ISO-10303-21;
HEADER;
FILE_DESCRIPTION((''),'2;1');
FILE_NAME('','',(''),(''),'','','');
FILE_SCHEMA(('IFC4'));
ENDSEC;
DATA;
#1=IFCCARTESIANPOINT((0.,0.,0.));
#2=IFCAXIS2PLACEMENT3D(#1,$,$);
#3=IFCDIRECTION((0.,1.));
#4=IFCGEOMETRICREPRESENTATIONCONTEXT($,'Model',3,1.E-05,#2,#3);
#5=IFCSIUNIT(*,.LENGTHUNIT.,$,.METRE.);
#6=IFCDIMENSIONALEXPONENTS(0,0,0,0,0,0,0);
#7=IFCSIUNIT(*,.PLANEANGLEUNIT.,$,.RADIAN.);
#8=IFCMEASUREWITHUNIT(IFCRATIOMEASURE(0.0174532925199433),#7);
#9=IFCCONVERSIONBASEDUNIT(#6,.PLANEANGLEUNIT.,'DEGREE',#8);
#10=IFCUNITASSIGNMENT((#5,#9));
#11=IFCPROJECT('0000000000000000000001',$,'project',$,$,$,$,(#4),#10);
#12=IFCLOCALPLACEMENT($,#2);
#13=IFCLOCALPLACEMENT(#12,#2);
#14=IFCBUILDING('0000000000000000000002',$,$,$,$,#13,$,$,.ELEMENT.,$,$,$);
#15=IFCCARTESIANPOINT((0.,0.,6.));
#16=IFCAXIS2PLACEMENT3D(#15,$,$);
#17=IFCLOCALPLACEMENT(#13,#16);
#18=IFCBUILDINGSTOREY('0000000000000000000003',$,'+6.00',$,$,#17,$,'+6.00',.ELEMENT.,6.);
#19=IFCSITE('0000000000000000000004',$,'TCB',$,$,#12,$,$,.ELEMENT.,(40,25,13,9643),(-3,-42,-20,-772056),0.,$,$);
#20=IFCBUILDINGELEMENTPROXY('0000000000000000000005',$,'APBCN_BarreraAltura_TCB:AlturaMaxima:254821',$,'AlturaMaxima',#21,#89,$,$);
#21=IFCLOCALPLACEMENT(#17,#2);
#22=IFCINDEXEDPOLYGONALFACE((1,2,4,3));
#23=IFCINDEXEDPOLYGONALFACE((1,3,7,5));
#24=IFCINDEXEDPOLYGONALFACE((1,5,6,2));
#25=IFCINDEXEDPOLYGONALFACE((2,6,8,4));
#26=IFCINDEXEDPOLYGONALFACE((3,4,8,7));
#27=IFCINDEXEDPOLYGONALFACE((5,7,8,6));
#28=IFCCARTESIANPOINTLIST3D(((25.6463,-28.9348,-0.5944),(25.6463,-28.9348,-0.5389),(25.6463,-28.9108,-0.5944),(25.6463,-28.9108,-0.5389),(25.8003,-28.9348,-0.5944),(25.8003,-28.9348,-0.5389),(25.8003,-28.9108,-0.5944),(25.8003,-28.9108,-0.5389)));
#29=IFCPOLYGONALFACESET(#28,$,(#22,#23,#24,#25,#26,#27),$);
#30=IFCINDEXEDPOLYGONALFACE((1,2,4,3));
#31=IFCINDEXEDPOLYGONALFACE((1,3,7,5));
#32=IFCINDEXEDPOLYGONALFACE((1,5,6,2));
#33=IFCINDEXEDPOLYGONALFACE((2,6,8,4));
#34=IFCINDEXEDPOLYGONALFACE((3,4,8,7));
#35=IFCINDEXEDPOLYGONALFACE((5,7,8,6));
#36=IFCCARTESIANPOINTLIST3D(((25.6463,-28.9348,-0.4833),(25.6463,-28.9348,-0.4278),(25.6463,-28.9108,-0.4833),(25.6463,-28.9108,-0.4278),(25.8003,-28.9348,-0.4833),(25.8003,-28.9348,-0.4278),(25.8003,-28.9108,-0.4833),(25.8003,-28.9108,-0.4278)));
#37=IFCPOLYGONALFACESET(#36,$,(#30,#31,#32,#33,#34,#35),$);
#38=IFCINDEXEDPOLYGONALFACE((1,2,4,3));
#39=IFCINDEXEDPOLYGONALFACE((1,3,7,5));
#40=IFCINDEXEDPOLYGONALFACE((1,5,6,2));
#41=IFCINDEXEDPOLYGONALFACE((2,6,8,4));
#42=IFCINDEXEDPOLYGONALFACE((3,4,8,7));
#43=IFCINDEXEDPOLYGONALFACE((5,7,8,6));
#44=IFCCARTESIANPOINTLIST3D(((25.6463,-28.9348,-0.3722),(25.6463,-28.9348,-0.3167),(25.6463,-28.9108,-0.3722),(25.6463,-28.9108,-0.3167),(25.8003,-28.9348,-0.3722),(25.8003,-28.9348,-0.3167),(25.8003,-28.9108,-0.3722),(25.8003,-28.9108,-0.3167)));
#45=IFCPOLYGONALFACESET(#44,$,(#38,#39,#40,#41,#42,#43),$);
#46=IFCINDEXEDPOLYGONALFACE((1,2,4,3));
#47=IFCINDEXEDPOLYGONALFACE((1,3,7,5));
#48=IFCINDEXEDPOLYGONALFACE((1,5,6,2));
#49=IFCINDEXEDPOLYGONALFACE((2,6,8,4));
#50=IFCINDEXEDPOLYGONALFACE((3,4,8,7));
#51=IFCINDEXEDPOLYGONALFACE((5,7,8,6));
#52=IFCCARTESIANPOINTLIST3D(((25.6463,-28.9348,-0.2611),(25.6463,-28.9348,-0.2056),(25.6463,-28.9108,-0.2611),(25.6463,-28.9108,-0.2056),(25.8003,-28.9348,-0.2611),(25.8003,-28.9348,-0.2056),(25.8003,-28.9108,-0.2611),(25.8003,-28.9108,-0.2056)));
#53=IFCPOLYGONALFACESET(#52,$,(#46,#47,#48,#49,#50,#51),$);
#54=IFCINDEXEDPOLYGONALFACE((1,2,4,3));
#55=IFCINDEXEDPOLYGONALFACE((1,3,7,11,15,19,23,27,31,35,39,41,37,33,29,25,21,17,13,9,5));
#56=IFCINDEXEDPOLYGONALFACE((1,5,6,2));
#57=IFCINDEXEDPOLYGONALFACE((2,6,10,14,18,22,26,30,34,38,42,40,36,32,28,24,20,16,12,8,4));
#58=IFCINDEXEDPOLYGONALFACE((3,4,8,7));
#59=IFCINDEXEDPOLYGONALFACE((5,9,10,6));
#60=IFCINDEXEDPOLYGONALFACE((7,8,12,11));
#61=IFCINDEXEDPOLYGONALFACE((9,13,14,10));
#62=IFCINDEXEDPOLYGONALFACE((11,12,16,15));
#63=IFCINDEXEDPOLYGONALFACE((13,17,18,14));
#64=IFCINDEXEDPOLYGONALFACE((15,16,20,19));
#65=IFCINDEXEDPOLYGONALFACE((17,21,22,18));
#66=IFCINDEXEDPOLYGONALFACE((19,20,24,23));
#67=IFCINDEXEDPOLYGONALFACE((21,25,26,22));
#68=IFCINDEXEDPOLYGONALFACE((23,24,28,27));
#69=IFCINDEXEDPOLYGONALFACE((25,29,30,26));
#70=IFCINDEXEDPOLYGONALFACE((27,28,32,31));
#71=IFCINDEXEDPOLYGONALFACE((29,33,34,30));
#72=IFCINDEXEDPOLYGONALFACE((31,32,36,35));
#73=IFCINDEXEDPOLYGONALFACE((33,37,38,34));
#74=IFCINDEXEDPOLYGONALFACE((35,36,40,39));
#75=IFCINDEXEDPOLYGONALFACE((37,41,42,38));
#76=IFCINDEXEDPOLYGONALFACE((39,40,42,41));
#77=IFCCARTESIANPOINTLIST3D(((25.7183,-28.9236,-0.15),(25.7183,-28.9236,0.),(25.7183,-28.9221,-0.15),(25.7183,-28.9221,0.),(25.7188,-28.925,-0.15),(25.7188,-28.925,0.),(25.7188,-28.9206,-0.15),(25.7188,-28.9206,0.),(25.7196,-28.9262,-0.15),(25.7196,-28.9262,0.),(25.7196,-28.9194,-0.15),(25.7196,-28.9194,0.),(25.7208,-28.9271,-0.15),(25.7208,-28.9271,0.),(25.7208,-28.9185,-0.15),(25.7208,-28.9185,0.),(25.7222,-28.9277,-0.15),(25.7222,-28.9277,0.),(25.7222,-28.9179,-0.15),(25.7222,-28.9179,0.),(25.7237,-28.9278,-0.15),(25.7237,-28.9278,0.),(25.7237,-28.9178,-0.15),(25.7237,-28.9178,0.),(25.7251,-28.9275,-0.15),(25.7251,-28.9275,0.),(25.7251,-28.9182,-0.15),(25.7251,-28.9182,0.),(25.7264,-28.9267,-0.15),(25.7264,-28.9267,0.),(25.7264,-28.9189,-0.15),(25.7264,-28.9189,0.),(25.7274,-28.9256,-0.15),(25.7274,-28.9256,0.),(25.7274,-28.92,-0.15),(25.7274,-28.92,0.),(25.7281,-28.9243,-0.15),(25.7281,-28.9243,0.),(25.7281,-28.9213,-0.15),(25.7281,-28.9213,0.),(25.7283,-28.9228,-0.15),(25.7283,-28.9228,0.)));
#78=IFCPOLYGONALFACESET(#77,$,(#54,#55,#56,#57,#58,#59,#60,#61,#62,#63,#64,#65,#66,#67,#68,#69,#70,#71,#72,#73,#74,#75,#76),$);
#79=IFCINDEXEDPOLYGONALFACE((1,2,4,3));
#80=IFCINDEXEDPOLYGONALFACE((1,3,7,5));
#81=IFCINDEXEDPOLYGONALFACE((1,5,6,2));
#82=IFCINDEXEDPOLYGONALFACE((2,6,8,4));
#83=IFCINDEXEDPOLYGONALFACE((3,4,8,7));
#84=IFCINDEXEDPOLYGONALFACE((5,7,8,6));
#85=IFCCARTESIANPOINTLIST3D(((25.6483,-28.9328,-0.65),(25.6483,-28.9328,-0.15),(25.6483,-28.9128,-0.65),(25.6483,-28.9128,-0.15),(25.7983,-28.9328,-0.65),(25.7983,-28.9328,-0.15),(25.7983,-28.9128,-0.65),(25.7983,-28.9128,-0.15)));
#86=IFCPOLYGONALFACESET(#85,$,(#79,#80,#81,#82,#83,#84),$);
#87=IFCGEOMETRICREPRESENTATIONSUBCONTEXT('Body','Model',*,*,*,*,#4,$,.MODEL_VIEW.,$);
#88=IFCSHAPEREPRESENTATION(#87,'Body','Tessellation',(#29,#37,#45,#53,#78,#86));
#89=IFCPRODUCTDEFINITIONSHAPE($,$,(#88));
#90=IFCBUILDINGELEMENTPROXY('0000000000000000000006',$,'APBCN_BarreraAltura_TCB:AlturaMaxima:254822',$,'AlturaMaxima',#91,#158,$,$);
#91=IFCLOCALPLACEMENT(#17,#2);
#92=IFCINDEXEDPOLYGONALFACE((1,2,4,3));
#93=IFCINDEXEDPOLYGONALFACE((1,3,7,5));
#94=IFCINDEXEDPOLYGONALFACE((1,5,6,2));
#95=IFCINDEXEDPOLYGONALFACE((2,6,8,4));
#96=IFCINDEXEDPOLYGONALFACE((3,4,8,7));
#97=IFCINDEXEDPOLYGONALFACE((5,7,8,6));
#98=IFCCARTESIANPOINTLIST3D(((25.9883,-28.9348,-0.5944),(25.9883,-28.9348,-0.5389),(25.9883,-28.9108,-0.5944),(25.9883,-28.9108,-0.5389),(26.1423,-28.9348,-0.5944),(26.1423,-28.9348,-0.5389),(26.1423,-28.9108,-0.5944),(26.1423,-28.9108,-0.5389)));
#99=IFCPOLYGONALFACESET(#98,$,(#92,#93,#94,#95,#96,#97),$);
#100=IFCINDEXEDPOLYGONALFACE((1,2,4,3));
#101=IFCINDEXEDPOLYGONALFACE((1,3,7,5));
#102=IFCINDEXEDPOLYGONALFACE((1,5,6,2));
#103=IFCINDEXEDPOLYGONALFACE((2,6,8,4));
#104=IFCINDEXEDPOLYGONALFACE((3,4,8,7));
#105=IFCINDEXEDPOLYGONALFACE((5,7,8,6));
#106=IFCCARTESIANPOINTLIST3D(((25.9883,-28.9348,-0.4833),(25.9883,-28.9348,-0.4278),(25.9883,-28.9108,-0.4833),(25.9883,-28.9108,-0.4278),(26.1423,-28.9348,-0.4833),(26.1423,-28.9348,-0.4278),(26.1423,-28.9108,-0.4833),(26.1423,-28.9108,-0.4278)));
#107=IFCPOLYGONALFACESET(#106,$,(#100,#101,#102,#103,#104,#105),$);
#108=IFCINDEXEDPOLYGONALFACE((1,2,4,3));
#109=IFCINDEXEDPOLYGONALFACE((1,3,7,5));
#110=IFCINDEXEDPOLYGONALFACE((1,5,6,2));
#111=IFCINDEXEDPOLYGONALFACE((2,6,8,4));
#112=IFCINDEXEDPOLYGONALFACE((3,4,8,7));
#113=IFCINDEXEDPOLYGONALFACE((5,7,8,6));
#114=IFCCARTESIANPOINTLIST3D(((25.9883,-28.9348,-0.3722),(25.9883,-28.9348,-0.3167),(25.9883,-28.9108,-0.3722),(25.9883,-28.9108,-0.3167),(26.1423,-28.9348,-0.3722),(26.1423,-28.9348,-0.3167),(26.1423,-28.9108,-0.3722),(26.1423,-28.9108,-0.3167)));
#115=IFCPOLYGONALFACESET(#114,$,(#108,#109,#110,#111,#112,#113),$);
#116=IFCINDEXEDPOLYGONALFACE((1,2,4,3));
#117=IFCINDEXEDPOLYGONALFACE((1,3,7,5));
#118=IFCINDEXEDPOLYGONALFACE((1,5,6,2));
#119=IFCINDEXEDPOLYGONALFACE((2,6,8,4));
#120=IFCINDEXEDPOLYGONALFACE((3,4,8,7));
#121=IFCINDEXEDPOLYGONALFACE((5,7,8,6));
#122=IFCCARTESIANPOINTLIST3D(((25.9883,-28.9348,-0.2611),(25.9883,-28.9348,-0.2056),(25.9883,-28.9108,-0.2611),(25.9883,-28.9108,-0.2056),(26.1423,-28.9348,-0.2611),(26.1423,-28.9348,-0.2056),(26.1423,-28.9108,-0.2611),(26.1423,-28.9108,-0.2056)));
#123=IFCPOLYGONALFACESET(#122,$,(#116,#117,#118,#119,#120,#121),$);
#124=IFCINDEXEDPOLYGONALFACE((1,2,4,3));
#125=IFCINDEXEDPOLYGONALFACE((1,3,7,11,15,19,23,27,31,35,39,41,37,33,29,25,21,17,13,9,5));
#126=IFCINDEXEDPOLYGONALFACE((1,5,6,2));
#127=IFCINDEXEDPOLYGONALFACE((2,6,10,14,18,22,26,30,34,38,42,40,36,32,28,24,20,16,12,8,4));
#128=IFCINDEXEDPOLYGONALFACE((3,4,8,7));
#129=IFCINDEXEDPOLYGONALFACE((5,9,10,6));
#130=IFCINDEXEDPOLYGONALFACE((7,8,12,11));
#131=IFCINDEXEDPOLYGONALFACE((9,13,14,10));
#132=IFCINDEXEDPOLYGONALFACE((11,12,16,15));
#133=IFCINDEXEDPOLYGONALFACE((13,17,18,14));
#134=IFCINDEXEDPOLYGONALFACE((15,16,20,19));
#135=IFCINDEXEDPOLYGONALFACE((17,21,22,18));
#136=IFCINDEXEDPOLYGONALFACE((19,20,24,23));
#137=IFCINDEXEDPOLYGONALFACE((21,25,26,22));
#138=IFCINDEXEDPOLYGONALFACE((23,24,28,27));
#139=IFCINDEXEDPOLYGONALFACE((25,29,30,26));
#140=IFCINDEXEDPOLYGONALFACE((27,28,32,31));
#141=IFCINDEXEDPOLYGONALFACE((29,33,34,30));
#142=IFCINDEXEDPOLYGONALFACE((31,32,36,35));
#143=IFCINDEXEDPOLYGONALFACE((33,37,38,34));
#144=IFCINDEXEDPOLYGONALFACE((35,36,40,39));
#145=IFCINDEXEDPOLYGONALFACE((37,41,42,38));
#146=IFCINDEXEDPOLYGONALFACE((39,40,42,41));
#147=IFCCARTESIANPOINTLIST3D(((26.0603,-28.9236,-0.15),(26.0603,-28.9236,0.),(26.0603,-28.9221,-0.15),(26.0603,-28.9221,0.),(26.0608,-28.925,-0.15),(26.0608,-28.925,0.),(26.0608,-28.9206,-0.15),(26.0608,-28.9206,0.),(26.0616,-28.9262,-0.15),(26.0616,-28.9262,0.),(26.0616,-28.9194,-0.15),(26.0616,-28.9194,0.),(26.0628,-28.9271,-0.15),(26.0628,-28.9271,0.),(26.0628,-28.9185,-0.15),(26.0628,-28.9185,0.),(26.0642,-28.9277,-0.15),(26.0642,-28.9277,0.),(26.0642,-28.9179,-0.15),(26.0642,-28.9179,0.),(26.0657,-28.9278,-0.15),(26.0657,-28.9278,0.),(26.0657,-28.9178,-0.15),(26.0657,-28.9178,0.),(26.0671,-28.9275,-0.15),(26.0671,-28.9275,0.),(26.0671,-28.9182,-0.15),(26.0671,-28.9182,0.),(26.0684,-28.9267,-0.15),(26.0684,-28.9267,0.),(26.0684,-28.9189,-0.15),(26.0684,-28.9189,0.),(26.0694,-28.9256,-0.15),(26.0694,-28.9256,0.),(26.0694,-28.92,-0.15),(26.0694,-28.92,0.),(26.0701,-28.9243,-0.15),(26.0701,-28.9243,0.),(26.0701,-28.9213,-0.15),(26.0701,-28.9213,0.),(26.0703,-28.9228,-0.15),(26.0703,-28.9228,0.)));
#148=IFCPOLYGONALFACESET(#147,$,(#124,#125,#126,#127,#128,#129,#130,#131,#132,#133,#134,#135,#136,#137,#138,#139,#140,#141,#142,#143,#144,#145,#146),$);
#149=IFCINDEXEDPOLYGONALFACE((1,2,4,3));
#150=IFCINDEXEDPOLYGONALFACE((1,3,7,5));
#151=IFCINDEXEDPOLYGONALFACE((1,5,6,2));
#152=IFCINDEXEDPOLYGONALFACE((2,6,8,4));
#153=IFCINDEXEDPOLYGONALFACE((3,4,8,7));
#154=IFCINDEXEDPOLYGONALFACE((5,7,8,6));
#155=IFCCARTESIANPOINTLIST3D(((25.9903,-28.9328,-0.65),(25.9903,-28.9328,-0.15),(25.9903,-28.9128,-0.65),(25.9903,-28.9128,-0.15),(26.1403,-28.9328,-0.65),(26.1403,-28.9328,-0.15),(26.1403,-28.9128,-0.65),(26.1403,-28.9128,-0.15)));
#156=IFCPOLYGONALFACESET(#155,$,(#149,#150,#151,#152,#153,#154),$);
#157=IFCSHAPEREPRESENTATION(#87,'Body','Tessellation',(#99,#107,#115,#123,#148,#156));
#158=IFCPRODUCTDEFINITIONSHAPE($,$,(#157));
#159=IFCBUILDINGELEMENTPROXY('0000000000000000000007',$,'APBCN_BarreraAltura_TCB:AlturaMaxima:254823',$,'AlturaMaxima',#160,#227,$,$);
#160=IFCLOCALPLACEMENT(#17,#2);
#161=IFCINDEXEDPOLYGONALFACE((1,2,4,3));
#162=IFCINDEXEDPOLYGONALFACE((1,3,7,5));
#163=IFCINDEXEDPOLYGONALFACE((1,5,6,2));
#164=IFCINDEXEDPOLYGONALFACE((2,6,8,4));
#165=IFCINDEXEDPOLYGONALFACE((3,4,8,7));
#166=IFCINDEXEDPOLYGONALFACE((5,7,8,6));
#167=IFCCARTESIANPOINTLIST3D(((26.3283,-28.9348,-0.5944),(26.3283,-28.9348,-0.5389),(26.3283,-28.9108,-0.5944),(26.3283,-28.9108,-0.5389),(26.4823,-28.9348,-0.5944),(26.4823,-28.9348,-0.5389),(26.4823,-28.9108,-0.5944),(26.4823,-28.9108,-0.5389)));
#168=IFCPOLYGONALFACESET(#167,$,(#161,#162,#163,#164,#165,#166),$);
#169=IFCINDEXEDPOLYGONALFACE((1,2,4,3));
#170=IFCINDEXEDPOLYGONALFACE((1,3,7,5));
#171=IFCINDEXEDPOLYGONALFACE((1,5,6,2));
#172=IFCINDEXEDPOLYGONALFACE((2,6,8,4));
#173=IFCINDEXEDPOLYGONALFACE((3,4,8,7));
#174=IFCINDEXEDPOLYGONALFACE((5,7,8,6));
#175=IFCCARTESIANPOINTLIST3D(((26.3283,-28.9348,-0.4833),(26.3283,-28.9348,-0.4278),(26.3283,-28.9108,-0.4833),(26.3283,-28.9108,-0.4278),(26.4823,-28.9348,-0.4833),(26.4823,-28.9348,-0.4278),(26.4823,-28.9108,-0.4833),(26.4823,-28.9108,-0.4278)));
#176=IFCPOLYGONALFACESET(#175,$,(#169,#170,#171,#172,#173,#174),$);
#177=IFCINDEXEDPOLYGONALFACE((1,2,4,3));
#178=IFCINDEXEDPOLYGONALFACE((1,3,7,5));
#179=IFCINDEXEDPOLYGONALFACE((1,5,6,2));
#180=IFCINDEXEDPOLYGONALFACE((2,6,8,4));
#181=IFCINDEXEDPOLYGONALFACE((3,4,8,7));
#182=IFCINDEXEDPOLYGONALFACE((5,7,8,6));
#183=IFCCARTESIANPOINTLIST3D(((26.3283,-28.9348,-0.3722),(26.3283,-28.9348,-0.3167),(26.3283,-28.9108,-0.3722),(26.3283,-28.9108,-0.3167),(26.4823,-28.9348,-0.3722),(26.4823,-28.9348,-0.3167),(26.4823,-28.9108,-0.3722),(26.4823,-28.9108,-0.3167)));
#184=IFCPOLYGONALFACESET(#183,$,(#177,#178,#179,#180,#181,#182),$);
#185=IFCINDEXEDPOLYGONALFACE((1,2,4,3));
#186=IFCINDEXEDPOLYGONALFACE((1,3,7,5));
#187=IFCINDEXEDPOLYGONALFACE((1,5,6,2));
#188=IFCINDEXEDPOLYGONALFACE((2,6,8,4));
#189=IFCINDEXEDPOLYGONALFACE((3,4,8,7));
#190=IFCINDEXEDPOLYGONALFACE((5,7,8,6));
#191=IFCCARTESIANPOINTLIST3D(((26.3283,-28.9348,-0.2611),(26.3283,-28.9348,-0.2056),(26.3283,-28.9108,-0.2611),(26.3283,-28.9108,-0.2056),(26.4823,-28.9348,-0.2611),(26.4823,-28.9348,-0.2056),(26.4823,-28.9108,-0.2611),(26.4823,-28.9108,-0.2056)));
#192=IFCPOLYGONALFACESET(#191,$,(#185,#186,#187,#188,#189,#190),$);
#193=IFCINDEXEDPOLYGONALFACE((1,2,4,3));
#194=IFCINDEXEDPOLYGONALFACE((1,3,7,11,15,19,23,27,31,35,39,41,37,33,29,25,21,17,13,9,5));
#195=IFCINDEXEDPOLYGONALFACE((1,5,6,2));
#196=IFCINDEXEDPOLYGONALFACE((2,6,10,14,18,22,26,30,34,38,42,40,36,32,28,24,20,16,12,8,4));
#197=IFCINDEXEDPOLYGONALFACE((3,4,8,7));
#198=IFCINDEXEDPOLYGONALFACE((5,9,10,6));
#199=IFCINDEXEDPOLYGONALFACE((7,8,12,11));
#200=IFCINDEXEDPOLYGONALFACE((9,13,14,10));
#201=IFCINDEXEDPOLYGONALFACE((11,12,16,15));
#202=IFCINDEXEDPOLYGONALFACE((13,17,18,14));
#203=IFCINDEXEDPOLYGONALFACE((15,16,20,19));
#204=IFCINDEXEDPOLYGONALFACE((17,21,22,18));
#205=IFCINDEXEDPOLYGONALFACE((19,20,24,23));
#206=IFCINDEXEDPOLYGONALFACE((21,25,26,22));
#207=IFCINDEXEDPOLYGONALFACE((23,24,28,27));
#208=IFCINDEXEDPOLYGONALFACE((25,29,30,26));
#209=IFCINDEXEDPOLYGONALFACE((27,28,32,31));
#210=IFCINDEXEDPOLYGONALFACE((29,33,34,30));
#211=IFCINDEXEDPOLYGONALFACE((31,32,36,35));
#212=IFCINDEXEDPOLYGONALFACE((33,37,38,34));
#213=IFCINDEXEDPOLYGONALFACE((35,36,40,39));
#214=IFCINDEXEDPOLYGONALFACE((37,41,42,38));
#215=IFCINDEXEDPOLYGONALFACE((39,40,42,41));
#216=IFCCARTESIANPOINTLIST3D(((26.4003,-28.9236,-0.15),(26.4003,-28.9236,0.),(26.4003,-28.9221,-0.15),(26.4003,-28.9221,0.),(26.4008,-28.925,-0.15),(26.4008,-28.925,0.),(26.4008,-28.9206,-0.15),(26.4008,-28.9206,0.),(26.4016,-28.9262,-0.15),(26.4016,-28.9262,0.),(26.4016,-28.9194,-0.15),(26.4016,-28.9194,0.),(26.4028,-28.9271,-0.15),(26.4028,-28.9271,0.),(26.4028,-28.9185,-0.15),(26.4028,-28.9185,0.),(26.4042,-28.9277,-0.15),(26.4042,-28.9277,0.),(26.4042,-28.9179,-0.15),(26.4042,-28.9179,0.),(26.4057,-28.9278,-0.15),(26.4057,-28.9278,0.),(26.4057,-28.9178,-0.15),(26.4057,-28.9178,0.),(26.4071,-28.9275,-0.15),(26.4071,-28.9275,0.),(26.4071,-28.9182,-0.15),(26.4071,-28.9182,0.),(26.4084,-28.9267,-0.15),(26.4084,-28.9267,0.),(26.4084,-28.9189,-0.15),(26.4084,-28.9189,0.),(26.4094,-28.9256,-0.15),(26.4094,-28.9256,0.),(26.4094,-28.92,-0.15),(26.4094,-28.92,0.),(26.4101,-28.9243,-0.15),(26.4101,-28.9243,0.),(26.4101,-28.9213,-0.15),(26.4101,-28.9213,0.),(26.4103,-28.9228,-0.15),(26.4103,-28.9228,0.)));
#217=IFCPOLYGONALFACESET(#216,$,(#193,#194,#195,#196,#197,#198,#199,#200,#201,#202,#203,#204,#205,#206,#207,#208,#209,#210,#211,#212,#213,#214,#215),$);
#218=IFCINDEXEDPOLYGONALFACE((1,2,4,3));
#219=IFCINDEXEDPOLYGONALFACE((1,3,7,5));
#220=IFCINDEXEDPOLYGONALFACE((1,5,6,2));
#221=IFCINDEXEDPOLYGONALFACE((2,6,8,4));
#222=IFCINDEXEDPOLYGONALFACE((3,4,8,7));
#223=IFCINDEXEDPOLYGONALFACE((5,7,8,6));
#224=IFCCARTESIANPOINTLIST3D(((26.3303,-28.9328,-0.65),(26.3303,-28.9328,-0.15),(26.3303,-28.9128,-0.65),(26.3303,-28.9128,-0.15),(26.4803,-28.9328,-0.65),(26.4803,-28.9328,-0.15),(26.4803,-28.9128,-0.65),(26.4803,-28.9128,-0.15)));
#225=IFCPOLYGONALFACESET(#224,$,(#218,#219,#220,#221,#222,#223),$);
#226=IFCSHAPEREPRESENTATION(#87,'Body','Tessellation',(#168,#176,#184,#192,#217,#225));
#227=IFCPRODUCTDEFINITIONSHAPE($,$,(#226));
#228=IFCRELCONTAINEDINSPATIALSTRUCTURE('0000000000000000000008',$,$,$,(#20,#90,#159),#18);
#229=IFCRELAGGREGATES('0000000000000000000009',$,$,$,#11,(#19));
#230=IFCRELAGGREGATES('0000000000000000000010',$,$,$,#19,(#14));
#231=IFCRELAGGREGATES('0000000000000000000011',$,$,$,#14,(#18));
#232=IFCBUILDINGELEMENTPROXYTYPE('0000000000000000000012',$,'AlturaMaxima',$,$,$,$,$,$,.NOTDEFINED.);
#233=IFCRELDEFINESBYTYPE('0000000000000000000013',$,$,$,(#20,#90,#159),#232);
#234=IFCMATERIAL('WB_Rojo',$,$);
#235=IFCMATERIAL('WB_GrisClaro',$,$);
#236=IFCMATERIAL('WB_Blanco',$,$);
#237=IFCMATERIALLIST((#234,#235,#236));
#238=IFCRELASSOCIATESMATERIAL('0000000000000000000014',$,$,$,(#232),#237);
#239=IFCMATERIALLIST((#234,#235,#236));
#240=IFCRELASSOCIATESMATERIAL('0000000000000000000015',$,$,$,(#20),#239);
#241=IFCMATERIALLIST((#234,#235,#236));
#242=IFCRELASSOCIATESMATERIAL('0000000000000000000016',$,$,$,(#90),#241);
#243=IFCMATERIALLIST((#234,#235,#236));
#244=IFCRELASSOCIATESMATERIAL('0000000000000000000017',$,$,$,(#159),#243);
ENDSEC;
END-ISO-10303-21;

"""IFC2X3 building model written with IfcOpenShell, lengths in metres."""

from ifc_helpers import new_model, entity, si_unit, converted_unit, direction, frame, frame_2d, origin, origin_2d_with_axis, place, context, subcontext, project, spatial, rectangle, circle, extrude, source, transform, mapped, material, material_list, type_object, type_shapes, element, save


model = new_model("IFC2X3")

# Units and contexts
model_context = context("Model", 3, precision=1e-05, world=origin(), true_north=direction((0.0, 1.0)))
body_context = subcontext(model_context, "Body", "Model", "MODEL_VIEW")
ifc_project = project(units=[si_unit("LENGTHUNIT", "METRE"), converted_unit("PLANEANGLEUNIT", "DEGREE", entity("IfcRatioMeasure", 0.0174532925199433), si_unit("PLANEANGLEUNIT", "RADIAN"), dimensions=[0, 0, 0, 0, 0, 0, 0])], contexts=[model_context])

# Site, building, storey
site_placement = place(None, origin())
site = spatial("IfcSite", under=ifc_project, at=site_placement, Name="TCB", CompositionType="ELEMENT", RefLatitude=(40, 25, 13, 9643), RefLongitude=(-3, -42, -20, -772056), RefElevation=0.0)
building_placement = place(site_placement, origin())
building = spatial("IfcBuilding", under=site, at=building_placement, CompositionType="ELEMENT")
storey_placement = place(building_placement, frame((0.0, 0.0, 6.0)))
storey = spatial("IfcBuildingStorey", under=building, at=storey_placement, Name="+6.00", LongName="+6.00", CompositionType="ELEMENT", Elevation=6.0)

# Building element proxies
ifc_material_1 = material(Name="WB_Rojo")
ifc_material_2 = material(Name="WB_GrisClaro")
ifc_material_3 = material(Name="WB_Blanco")
ifc_material_list_1 = material_list([ifc_material_1, ifc_material_2, ifc_material_3])
building_element_proxy_type = type_object("IfcBuildingElementProxyType", Name="AlturaMaxima", PredefinedType="NOTDEFINED", material=ifc_material_list_1)
shared_shape = source(origin(), body_context, "Body", "SweptSolid", [
    extrude(rectangle(XDim=0.154, YDim=0.024, at=frame_2d((0.0, 0.0), x_axis=(1.0, 0.0))), frame((0.0, 0.0, -0.5944), z_axis=(0.0, 0.0, 1.0), x_axis=(-1.0, 0.0, 0.0)), (0.0, 0.0, 1.0), 0.0556),
    extrude(rectangle(XDim=0.154, YDim=0.024, at=frame_2d((0.0, 0.0), x_axis=(1.0, 0.0))), frame((0.0, 0.0, -0.4833), z_axis=(0.0, 0.0, 1.0), x_axis=(-1.0, 0.0, 0.0)), (0.0, 0.0, 1.0), 0.0556),
    extrude(rectangle(XDim=0.154, YDim=0.024, at=frame_2d((0.0, 0.0), x_axis=(1.0, 0.0))), frame((0.0, 0.0, -0.3722), z_axis=(0.0, 0.0, 1.0), x_axis=(-1.0, 0.0, 0.0)), (0.0, 0.0, 1.0), 0.0556),
    extrude(rectangle(XDim=0.154, YDim=0.024, at=frame_2d((0.0, 0.0), x_axis=(1.0, 0.0))), frame((0.0, 0.0, -0.2611), z_axis=(0.0, 0.0, 1.0), x_axis=(-1.0, 0.0, 0.0)), (0.0, 0.0, 1.0), 0.0556),
    extrude(circle(Radius=0.005, at=frame_2d((0.0, 0.0), x_axis=(1.0, 0.0))), frame((0.0, 0.0, -0.15)), (0.0, 0.0, 1.0), 0.15),
    extrude(rectangle(XDim=0.02, YDim=0.15, at=origin_2d_with_axis()), frame((0.0, 0.0, -0.65), z_axis=(0.0, 0.0, 1.0), x_axis=(0.0, 1.0, 0.0)), (0.0, 0.0, 1.0), 0.5),
])
type_shapes(building_element_proxy_type, [shared_shape])
ifc_material_list_2 = material_list([ifc_material_1, ifc_material_2, ifc_material_3])
proxy_1_placement = place(storey_placement, frame((25.7233, -28.9228, 0.0)))
element("IfcBuildingElementProxy", 1, at=proxy_1_placement, inside=storey, type_object=building_element_proxy_type, material=ifc_material_list_2, Name="APBCN_BarreraAltura_TCB:AlturaMaxima:254821", ObjectType="AlturaMaxima", context=body_context, shape_type="MappedRepresentation", body=[
    mapped(shared_shape, transform((0.0, 0.0, 0.0), scale=1.0)),
])
ifc_material_list_3 = material_list([ifc_material_1, ifc_material_2, ifc_material_3])
proxy_2_placement = place(storey_placement, frame((26.0653, -28.9228, 0.0)))
element("IfcBuildingElementProxy", 2, at=proxy_2_placement, inside=storey, type_object=building_element_proxy_type, material=ifc_material_list_3, Name="APBCN_BarreraAltura_TCB:AlturaMaxima:254822", ObjectType="AlturaMaxima", context=body_context, shape_type="MappedRepresentation", body=[
    mapped(shared_shape, transform((0.0, 0.0, 0.0), scale=1.0)),
])
ifc_material_list_4 = material_list([ifc_material_1, ifc_material_2, ifc_material_3])
proxy_3_placement = place(storey_placement, frame((26.4053, -28.9228, 0.0)))
element("IfcBuildingElementProxy", 3, at=proxy_3_placement, inside=storey, type_object=building_element_proxy_type, material=ifc_material_list_4, Name="APBCN_BarreraAltura_TCB:AlturaMaxima:254823", ObjectType="AlturaMaxima", context=body_context, shape_type="MappedRepresentation", body=[
    mapped(shared_shape, transform((0.0, 0.0, 0.0), scale=1.0)),
])

save(model, "model.ifc")
